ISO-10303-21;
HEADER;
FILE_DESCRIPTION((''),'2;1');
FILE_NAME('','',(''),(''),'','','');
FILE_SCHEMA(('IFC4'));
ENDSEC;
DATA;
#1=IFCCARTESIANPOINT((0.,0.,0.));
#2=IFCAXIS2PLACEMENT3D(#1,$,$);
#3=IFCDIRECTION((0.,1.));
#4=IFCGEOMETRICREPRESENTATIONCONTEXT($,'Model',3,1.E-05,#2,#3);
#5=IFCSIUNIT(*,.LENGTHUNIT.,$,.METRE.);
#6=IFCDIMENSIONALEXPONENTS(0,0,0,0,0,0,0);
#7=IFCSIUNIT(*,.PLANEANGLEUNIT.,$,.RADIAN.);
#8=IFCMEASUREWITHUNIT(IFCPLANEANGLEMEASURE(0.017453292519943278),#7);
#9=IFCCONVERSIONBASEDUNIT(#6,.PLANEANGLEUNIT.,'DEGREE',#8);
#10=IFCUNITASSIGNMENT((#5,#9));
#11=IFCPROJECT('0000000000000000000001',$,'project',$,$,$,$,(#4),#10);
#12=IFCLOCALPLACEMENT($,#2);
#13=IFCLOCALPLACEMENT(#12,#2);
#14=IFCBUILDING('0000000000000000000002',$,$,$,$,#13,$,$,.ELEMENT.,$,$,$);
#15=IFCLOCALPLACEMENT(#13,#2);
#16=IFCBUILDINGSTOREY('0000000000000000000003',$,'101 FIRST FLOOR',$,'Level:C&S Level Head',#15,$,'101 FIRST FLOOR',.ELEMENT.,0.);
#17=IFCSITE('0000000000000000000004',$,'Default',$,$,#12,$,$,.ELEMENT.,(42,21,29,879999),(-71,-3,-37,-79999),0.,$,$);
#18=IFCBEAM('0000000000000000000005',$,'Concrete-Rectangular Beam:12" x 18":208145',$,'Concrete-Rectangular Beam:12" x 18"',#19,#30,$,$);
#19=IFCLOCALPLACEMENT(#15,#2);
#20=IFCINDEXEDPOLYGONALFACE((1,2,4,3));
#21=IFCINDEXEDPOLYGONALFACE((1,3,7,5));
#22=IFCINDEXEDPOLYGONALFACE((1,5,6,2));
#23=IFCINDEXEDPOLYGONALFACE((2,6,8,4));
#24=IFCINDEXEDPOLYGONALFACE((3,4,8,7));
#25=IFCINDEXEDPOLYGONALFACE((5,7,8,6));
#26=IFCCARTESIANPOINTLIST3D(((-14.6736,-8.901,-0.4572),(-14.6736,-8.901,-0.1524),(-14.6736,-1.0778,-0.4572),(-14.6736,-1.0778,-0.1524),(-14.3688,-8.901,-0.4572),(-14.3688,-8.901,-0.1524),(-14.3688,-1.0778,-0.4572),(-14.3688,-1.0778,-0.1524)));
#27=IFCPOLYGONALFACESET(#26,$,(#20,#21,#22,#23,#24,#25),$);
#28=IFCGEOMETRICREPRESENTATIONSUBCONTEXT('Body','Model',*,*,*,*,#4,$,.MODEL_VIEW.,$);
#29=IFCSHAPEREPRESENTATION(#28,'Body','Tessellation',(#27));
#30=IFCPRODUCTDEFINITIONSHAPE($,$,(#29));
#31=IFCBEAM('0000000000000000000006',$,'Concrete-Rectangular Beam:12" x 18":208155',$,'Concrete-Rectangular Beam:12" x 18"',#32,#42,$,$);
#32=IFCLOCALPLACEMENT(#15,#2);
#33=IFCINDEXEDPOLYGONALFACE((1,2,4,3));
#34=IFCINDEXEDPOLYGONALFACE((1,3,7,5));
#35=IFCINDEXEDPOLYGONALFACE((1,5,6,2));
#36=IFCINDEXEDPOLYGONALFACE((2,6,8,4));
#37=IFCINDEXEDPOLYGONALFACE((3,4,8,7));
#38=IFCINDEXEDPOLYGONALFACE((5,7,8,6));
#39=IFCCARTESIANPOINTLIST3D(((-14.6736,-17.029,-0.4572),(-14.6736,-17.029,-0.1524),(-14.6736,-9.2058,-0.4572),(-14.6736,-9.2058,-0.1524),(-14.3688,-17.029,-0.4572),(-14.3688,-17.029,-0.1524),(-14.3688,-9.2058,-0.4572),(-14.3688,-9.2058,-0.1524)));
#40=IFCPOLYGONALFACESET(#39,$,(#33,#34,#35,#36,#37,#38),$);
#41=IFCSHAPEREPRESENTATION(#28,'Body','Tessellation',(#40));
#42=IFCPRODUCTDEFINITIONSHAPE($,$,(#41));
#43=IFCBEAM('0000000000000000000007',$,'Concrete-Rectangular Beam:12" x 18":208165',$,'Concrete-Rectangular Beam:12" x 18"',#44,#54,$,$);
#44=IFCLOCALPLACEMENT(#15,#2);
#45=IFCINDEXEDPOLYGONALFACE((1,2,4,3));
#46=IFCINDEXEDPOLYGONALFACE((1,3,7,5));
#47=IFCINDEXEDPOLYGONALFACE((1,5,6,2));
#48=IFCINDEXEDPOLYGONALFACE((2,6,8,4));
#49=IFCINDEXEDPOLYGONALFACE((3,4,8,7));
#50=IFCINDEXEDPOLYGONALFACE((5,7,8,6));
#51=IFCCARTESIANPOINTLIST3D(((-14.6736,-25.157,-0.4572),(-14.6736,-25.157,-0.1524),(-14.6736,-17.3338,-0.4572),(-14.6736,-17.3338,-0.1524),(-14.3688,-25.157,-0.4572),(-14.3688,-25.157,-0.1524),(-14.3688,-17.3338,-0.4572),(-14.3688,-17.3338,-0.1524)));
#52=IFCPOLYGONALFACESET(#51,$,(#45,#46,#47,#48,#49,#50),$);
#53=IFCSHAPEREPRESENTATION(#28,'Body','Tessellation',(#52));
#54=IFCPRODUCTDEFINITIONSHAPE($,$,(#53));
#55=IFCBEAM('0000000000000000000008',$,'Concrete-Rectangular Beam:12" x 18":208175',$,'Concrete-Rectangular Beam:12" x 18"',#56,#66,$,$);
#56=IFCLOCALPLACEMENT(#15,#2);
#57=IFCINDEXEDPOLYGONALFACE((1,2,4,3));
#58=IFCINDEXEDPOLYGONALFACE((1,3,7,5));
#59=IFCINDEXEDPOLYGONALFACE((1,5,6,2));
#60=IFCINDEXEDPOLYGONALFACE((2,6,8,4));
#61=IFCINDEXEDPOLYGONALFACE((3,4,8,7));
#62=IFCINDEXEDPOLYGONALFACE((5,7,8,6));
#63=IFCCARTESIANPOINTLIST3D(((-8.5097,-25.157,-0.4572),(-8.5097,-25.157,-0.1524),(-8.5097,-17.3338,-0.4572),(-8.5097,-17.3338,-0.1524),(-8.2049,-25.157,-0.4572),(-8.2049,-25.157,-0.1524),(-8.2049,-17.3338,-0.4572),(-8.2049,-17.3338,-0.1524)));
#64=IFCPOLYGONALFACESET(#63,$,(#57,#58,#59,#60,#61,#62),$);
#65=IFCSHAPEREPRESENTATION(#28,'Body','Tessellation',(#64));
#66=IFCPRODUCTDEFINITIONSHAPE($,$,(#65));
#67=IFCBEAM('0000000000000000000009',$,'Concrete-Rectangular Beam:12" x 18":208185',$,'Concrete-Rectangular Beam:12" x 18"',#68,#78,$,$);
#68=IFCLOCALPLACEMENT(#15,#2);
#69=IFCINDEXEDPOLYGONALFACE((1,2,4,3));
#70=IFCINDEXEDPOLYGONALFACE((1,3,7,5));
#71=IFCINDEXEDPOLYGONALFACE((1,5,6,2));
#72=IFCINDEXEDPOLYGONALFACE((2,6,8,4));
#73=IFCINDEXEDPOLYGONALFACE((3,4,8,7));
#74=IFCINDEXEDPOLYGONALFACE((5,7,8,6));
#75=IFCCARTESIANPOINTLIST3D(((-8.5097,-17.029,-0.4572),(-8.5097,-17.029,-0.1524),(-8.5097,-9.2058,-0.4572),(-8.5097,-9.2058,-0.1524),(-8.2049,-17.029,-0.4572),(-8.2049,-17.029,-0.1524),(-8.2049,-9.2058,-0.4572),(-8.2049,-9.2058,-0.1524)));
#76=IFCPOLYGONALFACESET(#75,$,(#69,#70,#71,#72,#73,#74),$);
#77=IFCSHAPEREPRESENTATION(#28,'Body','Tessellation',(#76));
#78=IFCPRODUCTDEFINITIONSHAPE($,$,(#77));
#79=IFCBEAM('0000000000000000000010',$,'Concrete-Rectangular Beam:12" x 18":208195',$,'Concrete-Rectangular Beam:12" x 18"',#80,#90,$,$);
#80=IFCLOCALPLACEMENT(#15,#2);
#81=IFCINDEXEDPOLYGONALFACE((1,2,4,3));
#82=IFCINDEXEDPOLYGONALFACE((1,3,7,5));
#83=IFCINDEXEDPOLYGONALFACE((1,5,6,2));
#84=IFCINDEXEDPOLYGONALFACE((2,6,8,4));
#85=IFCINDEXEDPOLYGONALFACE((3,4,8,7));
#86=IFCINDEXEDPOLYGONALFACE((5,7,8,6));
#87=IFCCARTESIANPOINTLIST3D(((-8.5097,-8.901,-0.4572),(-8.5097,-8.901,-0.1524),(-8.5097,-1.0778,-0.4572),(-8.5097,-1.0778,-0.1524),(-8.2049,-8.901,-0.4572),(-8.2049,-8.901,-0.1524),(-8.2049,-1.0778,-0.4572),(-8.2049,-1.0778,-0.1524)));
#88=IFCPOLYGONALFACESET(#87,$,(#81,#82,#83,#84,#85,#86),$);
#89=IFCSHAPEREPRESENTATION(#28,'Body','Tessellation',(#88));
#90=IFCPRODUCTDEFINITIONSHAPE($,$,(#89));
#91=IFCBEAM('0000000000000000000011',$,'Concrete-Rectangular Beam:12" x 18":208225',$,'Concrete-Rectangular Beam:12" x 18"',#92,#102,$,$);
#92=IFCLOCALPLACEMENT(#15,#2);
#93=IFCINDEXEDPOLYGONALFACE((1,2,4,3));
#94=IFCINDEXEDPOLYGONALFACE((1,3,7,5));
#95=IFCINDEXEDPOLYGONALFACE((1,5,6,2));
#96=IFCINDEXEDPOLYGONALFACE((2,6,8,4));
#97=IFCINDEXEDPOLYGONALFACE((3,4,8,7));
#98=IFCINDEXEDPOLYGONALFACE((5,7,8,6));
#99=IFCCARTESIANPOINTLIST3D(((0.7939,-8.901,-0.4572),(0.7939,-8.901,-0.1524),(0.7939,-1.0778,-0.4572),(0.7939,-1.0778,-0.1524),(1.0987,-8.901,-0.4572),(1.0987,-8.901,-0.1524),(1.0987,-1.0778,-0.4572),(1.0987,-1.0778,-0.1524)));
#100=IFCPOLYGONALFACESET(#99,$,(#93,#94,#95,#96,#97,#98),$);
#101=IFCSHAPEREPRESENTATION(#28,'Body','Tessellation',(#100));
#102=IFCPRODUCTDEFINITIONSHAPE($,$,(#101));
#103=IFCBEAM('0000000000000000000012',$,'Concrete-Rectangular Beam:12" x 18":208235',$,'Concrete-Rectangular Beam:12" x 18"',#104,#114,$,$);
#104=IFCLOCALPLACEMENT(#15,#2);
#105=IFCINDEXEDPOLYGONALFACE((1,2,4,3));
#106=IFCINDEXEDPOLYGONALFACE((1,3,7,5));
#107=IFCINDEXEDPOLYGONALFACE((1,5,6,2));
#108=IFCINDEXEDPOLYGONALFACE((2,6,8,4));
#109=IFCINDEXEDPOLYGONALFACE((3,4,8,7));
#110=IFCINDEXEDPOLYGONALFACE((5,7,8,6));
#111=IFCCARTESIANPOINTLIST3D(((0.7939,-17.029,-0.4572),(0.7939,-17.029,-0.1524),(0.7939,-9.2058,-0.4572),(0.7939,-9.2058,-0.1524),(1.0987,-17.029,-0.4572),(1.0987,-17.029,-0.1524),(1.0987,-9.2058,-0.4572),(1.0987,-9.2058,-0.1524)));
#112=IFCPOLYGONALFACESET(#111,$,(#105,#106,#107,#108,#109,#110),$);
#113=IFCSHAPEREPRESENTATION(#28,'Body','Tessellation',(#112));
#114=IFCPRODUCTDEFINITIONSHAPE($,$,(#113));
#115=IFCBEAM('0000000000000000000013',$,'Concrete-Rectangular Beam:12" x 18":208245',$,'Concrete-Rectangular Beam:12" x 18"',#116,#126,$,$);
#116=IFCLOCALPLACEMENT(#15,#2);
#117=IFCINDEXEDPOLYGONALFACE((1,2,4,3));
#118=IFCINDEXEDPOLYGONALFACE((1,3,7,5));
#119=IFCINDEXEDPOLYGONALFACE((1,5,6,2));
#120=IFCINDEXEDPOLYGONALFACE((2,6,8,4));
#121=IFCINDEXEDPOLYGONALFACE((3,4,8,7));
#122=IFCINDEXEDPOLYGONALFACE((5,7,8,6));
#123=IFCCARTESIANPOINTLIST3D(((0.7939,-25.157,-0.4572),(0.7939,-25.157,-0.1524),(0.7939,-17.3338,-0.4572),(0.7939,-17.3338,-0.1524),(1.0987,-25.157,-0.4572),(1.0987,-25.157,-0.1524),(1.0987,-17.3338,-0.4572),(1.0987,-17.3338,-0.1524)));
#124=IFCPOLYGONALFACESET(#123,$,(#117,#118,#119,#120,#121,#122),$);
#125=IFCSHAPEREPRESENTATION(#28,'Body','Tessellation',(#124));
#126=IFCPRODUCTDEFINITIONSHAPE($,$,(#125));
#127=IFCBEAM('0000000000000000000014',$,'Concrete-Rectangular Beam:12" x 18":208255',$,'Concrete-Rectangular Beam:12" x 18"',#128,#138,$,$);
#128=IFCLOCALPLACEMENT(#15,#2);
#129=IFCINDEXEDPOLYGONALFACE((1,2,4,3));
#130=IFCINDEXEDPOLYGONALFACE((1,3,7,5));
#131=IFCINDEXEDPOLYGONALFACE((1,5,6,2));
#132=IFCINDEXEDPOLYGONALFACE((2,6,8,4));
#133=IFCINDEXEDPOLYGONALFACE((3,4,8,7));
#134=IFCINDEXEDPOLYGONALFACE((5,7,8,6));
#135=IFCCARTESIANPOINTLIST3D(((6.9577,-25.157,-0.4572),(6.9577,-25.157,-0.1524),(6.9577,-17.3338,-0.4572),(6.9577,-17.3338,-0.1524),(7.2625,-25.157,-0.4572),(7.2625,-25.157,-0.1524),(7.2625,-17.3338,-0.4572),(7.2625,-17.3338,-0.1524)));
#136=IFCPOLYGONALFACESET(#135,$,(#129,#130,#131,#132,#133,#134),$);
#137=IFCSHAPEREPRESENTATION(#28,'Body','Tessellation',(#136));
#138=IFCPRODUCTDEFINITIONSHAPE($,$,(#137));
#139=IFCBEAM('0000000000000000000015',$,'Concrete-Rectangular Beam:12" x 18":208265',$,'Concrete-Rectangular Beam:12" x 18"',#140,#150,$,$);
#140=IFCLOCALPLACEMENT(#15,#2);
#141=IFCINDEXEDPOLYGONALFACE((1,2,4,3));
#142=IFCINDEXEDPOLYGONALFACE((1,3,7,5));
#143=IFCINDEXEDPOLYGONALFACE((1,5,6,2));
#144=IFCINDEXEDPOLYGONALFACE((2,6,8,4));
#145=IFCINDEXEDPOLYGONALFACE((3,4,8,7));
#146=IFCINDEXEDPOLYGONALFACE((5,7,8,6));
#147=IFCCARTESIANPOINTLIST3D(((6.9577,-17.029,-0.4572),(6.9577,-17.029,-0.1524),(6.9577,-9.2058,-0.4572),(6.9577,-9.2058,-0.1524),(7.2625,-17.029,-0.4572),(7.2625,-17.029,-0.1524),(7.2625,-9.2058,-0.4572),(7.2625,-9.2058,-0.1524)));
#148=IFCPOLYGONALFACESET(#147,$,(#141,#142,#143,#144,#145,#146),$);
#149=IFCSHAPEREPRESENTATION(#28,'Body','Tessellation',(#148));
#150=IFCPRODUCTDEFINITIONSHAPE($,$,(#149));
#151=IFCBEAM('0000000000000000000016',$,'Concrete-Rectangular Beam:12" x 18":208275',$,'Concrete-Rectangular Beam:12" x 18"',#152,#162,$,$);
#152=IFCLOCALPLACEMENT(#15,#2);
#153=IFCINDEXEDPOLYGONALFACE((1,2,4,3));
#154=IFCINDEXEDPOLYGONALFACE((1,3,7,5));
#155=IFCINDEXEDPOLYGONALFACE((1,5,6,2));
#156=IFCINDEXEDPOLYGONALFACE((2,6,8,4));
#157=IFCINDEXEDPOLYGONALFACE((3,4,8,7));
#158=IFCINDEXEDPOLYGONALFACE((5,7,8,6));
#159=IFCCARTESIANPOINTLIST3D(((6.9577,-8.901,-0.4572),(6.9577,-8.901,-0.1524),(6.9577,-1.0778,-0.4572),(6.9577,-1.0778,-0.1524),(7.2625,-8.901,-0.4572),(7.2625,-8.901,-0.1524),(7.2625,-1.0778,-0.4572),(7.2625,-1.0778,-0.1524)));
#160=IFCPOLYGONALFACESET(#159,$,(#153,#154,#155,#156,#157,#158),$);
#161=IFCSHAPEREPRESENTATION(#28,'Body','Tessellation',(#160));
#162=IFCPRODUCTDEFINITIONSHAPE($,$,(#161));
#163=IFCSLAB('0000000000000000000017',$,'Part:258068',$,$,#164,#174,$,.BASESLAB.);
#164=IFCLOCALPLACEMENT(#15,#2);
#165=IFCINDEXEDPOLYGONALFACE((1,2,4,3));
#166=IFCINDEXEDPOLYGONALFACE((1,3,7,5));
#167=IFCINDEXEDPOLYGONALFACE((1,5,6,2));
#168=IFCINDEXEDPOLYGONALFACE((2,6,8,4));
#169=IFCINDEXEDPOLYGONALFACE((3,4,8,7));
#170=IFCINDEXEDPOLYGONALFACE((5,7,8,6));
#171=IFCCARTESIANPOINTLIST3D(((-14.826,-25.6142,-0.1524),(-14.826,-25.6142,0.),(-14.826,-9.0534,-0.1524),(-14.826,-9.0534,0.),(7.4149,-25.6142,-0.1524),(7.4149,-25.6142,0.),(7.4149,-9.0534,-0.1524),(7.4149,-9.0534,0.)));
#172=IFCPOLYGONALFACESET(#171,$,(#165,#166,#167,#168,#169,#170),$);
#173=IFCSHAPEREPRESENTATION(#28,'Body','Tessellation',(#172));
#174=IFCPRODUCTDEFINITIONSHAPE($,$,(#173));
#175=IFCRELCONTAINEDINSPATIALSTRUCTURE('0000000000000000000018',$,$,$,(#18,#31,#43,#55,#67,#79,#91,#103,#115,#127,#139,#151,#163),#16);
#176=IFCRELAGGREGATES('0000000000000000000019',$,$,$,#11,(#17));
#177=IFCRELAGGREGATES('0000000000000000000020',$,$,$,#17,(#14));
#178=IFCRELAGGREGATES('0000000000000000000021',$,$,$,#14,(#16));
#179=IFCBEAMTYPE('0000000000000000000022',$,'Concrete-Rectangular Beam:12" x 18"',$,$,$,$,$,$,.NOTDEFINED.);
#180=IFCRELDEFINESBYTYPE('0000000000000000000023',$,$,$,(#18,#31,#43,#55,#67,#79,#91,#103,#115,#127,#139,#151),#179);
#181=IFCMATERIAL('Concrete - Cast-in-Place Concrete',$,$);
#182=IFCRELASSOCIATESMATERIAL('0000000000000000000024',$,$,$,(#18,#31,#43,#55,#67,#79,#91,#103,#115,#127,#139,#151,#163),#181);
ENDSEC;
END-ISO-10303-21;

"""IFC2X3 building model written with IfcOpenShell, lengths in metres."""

from ifc_helpers import new_model, entity, si_unit, converted_unit, direction, frame, frame_2d, origin, place, context, subcontext, project, spatial, rectangle, extrude, material, type_object, element, save


model = new_model("IFC2X3")

# Units and contexts
model_context = context("Model", 3, precision=1e-05, world=origin(), true_north=direction((0.0, 1.0)))
body_context = subcontext(model_context, "Body", "Model", "MODEL_VIEW")
ifc_project = project(units=[si_unit("LENGTHUNIT", "METRE"), converted_unit("PLANEANGLEUNIT", "DEGREE", entity("IfcPlaneAngleMeasure", 0.017453292519943278), si_unit("PLANEANGLEUNIT", "RADIAN"), dimensions=[0, 0, 0, 0, 0, 0, 0])], contexts=[model_context])

# Site, building, storey
site_placement = place(None, origin())
site = spatial("IfcSite", under=ifc_project, at=site_placement, Name="Default", CompositionType="ELEMENT", RefLatitude=(42, 21, 29, 879999), RefLongitude=(-71, -3, -37, -79999), RefElevation=0.0)
building_placement = place(site_placement, origin())
building = spatial("IfcBuilding", under=site, at=building_placement, CompositionType="ELEMENT")
storey_placement = place(building_placement, origin())
storey = spatial("IfcBuildingStorey", under=building, at=storey_placement, Name="101 FIRST FLOOR", ObjectType="Level:C&S Level Head", LongName="101 FIRST FLOOR", CompositionType="ELEMENT", Elevation=0.0)

# Beams
ifc_material = material(Name="Concrete - Cast-in-Place Concrete")
beam_type = type_object("IfcBeamType", Name="Concrete-Rectangular Beam:12\" x 18\"", PredefinedType="NOTDEFINED")
beam_1_placement = place(storey_placement, frame((-14.5212, -1.0778, 0.0), z_axis=(0.0, 0.0, 1.0), x_axis=(0.0, -1.0, 0.0)))
element("IfcBeam", 1, at=beam_1_placement, inside=storey, type_object=beam_type, material=ifc_material, Name="Concrete-Rectangular Beam:12\" x 18\":208145", ObjectType="Concrete-Rectangular Beam:12\" x 18\"", context=body_context, shape_type="SweptSolid", body=[
    extrude(rectangle(XDim=0.3048, YDim=0.3048, at=frame_2d((0.0, 0.0), x_axis=(1.0, 0.0))), frame((0.0, 0.0, -0.3048), z_axis=(1.0, 0.0, 0.0), x_axis=(0.0, 0.0, -1.0)), (0.0, 0.0, 1.0), 7.8232),
])
beam_2_placement = place(storey_placement, frame((-14.5212, -9.2058, 0.0), z_axis=(0.0, 0.0, 1.0), x_axis=(0.0, -1.0, 0.0)))
element("IfcBeam", 2, at=beam_2_placement, inside=storey, type_object=beam_type, material=ifc_material, Name="Concrete-Rectangular Beam:12\" x 18\":208155", ObjectType="Concrete-Rectangular Beam:12\" x 18\"", context=body_context, shape_type="SweptSolid", body=[
    extrude(rectangle(XDim=0.3048, YDim=0.3048, at=frame_2d((0.0, 0.0), x_axis=(1.0, 0.0))), frame((0.0, 0.0, -0.3048), z_axis=(1.0, 0.0, 0.0), x_axis=(0.0, 0.0, -1.0)), (0.0, 0.0, 1.0), 7.8232),
])
beam_3_placement = place(storey_placement, frame((-14.5212, -17.3338, 0.0), z_axis=(0.0, 0.0, 1.0), x_axis=(0.0, -1.0, 0.0)))
element("IfcBeam", 3, at=beam_3_placement, inside=storey, type_object=beam_type, material=ifc_material, Name="Concrete-Rectangular Beam:12\" x 18\":208165", ObjectType="Concrete-Rectangular Beam:12\" x 18\"", context=body_context, shape_type="SweptSolid", body=[
    extrude(rectangle(XDim=0.3048, YDim=0.3048, at=frame_2d((0.0, 0.0), x_axis=(1.0, 0.0))), frame((0.0, 0.0, -0.3048), z_axis=(1.0, 0.0, 0.0), x_axis=(0.0, 0.0, -1.0)), (0.0, 0.0, 1.0), 7.8232),
])
beam_4_placement = place(storey_placement, frame((-8.3573, -17.3338, 0.0), z_axis=(0.0, 0.0, 1.0), x_axis=(0.0, -1.0, 0.0)))
element("IfcBeam", 4, at=beam_4_placement, inside=storey, type_object=beam_type, material=ifc_material, Name="Concrete-Rectangular Beam:12\" x 18\":208175", ObjectType="Concrete-Rectangular Beam:12\" x 18\"", context=body_context, shape_type="SweptSolid", body=[
    extrude(rectangle(XDim=0.3048, YDim=0.3048, at=frame_2d((0.0, 0.0), x_axis=(1.0, 0.0))), frame((0.0, 0.0, -0.3048), z_axis=(1.0, 0.0, 0.0), x_axis=(0.0, 0.0, -1.0)), (0.0, 0.0, 1.0), 7.8232),
])
beam_5_placement = place(storey_placement, frame((-8.3573, -9.2058, 0.0), z_axis=(0.0, 0.0, 1.0), x_axis=(0.0, -1.0, 0.0)))
element("IfcBeam", 5, at=beam_5_placement, inside=storey, type_object=beam_type, material=ifc_material, Name="Concrete-Rectangular Beam:12\" x 18\":208185", ObjectType="Concrete-Rectangular Beam:12\" x 18\"", context=body_context, shape_type="SweptSolid", body=[
    extrude(rectangle(XDim=0.3048, YDim=0.3048, at=frame_2d((0.0, 0.0), x_axis=(1.0, 0.0))), frame((0.0, 0.0, -0.3048), z_axis=(1.0, 0.0, 0.0), x_axis=(0.0, 0.0, -1.0)), (0.0, 0.0, 1.0), 7.8232),
])
beam_6_placement = place(storey_placement, frame((-8.3573, -1.0778, 0.0), z_axis=(0.0, 0.0, 1.0), x_axis=(0.0, -1.0, 0.0)))
element("IfcBeam", 6, at=beam_6_placement, inside=storey, type_object=beam_type, material=ifc_material, Name="Concrete-Rectangular Beam:12\" x 18\":208195", ObjectType="Concrete-Rectangular Beam:12\" x 18\"", context=body_context, shape_type="SweptSolid", body=[
    extrude(rectangle(XDim=0.3048, YDim=0.3048, at=frame_2d((0.0, 0.0), x_axis=(1.0, 0.0))), frame((0.0, 0.0, -0.3048), z_axis=(1.0, 0.0, 0.0), x_axis=(0.0, 0.0, -1.0)), (0.0, 0.0, 1.0), 7.8232),
])
beam_7_placement = place(storey_placement, frame((0.9463, -1.0778, 0.0), z_axis=(0.0, 0.0, 1.0), x_axis=(0.0, -1.0, 0.0)))
element("IfcBeam", 7, at=beam_7_placement, inside=storey, type_object=beam_type, material=ifc_material, Name="Concrete-Rectangular Beam:12\" x 18\":208225", ObjectType="Concrete-Rectangular Beam:12\" x 18\"", context=body_context, shape_type="SweptSolid", body=[
    extrude(rectangle(XDim=0.3048, YDim=0.3048, at=frame_2d((0.0, 0.0), x_axis=(1.0, 0.0))), frame((0.0, 0.0, -0.3048), z_axis=(1.0, 0.0, 0.0), x_axis=(0.0, 0.0, -1.0)), (0.0, 0.0, 1.0), 7.8232),
])
beam_8_placement = place(storey_placement, frame((0.9463, -9.2058, 0.0), z_axis=(0.0, 0.0, 1.0), x_axis=(0.0, -1.0, 0.0)))
element("IfcBeam", 8, at=beam_8_placement, inside=storey, type_object=beam_type, material=ifc_material, Name="Concrete-Rectangular Beam:12\" x 18\":208235", ObjectType="Concrete-Rectangular Beam:12\" x 18\"", context=body_context, shape_type="SweptSolid", body=[
    extrude(rectangle(XDim=0.3048, YDim=0.3048, at=frame_2d((0.0, 0.0), x_axis=(1.0, 0.0))), frame((0.0, 0.0, -0.3048), z_axis=(1.0, 0.0, 0.0), x_axis=(0.0, 0.0, -1.0)), (0.0, 0.0, 1.0), 7.8232),
])
beam_9_placement = place(storey_placement, frame((0.9463, -17.3338, 0.0), z_axis=(0.0, 0.0, 1.0), x_axis=(0.0, -1.0, 0.0)))
element("IfcBeam", 9, at=beam_9_placement, inside=storey, type_object=beam_type, material=ifc_material, Name="Concrete-Rectangular Beam:12\" x 18\":208245", ObjectType="Concrete-Rectangular Beam:12\" x 18\"", context=body_context, shape_type="SweptSolid", body=[
    extrude(rectangle(XDim=0.3048, YDim=0.3048, at=frame_2d((0.0, 0.0), x_axis=(1.0, 0.0))), frame((0.0, 0.0, -0.3048), z_axis=(1.0, 0.0, 0.0), x_axis=(0.0, 0.0, -1.0)), (0.0, 0.0, 1.0), 7.8232),
])
beam_10_placement = place(storey_placement, frame((7.1101, -17.3338, 0.0), z_axis=(0.0, 0.0, 1.0), x_axis=(0.0, -1.0, 0.0)))
element("IfcBeam", 10, at=beam_10_placement, inside=storey, type_object=beam_type, material=ifc_material, Name="Concrete-Rectangular Beam:12\" x 18\":208255", ObjectType="Concrete-Rectangular Beam:12\" x 18\"", context=body_context, shape_type="SweptSolid", body=[
    extrude(rectangle(XDim=0.3048, YDim=0.3048, at=frame_2d((0.0, 0.0), x_axis=(1.0, 0.0))), frame((0.0, 0.0, -0.3048), z_axis=(1.0, 0.0, 0.0), x_axis=(0.0, 0.0, -1.0)), (0.0, 0.0, 1.0), 7.8232),
])
for number, where, z_axis, x_axis, name in (
    (11, (7.1101, -9.2058, 0.0), (0.0, 0.0, 1.0), (0.0, -1.0, 0.0), "Concrete-Rectangular Beam:12\" x 18\":208265"),
    (12, (7.1101, -1.0778, 0.0), (0.0, 0.0, 1.0), (0.0, -1.0, 0.0), "Concrete-Rectangular Beam:12\" x 18\":208275"),
):
    element("IfcBeam", number, at=place(storey_placement, frame(where, z_axis=z_axis, x_axis=x_axis)), inside=storey, type_object=beam_type, material=ifc_material, Name=name, ObjectType="Concrete-Rectangular Beam:12\" x 18\"", context=body_context, shape_type="SweptSolid", body=[
        extrude(rectangle(XDim=0.3048, YDim=0.3048, at=frame_2d((0.0, 0.0), x_axis=(1.0, 0.0))), frame((0.0, 0.0, -0.3048), z_axis=(1.0, 0.0, 0.0), x_axis=(0.0, 0.0, -1.0)), (0.0, 0.0, 1.0), 7.8232),
    ])

# Slab
slab_placement = place(storey_placement, frame((0.0, 0.0, -0.1524)))
element("IfcSlab", 13, at=slab_placement, inside=storey, material=ifc_material, Name="Part:258068", PredefinedType="BASESLAB", context=body_context, shape_type="SweptSolid", body=[
    extrude(rectangle(XDim=0.1524, YDim=16.5608, at=frame_2d((0.0, 0.0), x_axis=(1.0, 0.0))), frame((-14.826, -17.3338, 0.0762), z_axis=(1.0, 0.0, 0.0), x_axis=(0.0, 0.0, -1.0)), (0.0, 0.0, 1.0), 22.2409),
])

save(model, "model.ifc")
